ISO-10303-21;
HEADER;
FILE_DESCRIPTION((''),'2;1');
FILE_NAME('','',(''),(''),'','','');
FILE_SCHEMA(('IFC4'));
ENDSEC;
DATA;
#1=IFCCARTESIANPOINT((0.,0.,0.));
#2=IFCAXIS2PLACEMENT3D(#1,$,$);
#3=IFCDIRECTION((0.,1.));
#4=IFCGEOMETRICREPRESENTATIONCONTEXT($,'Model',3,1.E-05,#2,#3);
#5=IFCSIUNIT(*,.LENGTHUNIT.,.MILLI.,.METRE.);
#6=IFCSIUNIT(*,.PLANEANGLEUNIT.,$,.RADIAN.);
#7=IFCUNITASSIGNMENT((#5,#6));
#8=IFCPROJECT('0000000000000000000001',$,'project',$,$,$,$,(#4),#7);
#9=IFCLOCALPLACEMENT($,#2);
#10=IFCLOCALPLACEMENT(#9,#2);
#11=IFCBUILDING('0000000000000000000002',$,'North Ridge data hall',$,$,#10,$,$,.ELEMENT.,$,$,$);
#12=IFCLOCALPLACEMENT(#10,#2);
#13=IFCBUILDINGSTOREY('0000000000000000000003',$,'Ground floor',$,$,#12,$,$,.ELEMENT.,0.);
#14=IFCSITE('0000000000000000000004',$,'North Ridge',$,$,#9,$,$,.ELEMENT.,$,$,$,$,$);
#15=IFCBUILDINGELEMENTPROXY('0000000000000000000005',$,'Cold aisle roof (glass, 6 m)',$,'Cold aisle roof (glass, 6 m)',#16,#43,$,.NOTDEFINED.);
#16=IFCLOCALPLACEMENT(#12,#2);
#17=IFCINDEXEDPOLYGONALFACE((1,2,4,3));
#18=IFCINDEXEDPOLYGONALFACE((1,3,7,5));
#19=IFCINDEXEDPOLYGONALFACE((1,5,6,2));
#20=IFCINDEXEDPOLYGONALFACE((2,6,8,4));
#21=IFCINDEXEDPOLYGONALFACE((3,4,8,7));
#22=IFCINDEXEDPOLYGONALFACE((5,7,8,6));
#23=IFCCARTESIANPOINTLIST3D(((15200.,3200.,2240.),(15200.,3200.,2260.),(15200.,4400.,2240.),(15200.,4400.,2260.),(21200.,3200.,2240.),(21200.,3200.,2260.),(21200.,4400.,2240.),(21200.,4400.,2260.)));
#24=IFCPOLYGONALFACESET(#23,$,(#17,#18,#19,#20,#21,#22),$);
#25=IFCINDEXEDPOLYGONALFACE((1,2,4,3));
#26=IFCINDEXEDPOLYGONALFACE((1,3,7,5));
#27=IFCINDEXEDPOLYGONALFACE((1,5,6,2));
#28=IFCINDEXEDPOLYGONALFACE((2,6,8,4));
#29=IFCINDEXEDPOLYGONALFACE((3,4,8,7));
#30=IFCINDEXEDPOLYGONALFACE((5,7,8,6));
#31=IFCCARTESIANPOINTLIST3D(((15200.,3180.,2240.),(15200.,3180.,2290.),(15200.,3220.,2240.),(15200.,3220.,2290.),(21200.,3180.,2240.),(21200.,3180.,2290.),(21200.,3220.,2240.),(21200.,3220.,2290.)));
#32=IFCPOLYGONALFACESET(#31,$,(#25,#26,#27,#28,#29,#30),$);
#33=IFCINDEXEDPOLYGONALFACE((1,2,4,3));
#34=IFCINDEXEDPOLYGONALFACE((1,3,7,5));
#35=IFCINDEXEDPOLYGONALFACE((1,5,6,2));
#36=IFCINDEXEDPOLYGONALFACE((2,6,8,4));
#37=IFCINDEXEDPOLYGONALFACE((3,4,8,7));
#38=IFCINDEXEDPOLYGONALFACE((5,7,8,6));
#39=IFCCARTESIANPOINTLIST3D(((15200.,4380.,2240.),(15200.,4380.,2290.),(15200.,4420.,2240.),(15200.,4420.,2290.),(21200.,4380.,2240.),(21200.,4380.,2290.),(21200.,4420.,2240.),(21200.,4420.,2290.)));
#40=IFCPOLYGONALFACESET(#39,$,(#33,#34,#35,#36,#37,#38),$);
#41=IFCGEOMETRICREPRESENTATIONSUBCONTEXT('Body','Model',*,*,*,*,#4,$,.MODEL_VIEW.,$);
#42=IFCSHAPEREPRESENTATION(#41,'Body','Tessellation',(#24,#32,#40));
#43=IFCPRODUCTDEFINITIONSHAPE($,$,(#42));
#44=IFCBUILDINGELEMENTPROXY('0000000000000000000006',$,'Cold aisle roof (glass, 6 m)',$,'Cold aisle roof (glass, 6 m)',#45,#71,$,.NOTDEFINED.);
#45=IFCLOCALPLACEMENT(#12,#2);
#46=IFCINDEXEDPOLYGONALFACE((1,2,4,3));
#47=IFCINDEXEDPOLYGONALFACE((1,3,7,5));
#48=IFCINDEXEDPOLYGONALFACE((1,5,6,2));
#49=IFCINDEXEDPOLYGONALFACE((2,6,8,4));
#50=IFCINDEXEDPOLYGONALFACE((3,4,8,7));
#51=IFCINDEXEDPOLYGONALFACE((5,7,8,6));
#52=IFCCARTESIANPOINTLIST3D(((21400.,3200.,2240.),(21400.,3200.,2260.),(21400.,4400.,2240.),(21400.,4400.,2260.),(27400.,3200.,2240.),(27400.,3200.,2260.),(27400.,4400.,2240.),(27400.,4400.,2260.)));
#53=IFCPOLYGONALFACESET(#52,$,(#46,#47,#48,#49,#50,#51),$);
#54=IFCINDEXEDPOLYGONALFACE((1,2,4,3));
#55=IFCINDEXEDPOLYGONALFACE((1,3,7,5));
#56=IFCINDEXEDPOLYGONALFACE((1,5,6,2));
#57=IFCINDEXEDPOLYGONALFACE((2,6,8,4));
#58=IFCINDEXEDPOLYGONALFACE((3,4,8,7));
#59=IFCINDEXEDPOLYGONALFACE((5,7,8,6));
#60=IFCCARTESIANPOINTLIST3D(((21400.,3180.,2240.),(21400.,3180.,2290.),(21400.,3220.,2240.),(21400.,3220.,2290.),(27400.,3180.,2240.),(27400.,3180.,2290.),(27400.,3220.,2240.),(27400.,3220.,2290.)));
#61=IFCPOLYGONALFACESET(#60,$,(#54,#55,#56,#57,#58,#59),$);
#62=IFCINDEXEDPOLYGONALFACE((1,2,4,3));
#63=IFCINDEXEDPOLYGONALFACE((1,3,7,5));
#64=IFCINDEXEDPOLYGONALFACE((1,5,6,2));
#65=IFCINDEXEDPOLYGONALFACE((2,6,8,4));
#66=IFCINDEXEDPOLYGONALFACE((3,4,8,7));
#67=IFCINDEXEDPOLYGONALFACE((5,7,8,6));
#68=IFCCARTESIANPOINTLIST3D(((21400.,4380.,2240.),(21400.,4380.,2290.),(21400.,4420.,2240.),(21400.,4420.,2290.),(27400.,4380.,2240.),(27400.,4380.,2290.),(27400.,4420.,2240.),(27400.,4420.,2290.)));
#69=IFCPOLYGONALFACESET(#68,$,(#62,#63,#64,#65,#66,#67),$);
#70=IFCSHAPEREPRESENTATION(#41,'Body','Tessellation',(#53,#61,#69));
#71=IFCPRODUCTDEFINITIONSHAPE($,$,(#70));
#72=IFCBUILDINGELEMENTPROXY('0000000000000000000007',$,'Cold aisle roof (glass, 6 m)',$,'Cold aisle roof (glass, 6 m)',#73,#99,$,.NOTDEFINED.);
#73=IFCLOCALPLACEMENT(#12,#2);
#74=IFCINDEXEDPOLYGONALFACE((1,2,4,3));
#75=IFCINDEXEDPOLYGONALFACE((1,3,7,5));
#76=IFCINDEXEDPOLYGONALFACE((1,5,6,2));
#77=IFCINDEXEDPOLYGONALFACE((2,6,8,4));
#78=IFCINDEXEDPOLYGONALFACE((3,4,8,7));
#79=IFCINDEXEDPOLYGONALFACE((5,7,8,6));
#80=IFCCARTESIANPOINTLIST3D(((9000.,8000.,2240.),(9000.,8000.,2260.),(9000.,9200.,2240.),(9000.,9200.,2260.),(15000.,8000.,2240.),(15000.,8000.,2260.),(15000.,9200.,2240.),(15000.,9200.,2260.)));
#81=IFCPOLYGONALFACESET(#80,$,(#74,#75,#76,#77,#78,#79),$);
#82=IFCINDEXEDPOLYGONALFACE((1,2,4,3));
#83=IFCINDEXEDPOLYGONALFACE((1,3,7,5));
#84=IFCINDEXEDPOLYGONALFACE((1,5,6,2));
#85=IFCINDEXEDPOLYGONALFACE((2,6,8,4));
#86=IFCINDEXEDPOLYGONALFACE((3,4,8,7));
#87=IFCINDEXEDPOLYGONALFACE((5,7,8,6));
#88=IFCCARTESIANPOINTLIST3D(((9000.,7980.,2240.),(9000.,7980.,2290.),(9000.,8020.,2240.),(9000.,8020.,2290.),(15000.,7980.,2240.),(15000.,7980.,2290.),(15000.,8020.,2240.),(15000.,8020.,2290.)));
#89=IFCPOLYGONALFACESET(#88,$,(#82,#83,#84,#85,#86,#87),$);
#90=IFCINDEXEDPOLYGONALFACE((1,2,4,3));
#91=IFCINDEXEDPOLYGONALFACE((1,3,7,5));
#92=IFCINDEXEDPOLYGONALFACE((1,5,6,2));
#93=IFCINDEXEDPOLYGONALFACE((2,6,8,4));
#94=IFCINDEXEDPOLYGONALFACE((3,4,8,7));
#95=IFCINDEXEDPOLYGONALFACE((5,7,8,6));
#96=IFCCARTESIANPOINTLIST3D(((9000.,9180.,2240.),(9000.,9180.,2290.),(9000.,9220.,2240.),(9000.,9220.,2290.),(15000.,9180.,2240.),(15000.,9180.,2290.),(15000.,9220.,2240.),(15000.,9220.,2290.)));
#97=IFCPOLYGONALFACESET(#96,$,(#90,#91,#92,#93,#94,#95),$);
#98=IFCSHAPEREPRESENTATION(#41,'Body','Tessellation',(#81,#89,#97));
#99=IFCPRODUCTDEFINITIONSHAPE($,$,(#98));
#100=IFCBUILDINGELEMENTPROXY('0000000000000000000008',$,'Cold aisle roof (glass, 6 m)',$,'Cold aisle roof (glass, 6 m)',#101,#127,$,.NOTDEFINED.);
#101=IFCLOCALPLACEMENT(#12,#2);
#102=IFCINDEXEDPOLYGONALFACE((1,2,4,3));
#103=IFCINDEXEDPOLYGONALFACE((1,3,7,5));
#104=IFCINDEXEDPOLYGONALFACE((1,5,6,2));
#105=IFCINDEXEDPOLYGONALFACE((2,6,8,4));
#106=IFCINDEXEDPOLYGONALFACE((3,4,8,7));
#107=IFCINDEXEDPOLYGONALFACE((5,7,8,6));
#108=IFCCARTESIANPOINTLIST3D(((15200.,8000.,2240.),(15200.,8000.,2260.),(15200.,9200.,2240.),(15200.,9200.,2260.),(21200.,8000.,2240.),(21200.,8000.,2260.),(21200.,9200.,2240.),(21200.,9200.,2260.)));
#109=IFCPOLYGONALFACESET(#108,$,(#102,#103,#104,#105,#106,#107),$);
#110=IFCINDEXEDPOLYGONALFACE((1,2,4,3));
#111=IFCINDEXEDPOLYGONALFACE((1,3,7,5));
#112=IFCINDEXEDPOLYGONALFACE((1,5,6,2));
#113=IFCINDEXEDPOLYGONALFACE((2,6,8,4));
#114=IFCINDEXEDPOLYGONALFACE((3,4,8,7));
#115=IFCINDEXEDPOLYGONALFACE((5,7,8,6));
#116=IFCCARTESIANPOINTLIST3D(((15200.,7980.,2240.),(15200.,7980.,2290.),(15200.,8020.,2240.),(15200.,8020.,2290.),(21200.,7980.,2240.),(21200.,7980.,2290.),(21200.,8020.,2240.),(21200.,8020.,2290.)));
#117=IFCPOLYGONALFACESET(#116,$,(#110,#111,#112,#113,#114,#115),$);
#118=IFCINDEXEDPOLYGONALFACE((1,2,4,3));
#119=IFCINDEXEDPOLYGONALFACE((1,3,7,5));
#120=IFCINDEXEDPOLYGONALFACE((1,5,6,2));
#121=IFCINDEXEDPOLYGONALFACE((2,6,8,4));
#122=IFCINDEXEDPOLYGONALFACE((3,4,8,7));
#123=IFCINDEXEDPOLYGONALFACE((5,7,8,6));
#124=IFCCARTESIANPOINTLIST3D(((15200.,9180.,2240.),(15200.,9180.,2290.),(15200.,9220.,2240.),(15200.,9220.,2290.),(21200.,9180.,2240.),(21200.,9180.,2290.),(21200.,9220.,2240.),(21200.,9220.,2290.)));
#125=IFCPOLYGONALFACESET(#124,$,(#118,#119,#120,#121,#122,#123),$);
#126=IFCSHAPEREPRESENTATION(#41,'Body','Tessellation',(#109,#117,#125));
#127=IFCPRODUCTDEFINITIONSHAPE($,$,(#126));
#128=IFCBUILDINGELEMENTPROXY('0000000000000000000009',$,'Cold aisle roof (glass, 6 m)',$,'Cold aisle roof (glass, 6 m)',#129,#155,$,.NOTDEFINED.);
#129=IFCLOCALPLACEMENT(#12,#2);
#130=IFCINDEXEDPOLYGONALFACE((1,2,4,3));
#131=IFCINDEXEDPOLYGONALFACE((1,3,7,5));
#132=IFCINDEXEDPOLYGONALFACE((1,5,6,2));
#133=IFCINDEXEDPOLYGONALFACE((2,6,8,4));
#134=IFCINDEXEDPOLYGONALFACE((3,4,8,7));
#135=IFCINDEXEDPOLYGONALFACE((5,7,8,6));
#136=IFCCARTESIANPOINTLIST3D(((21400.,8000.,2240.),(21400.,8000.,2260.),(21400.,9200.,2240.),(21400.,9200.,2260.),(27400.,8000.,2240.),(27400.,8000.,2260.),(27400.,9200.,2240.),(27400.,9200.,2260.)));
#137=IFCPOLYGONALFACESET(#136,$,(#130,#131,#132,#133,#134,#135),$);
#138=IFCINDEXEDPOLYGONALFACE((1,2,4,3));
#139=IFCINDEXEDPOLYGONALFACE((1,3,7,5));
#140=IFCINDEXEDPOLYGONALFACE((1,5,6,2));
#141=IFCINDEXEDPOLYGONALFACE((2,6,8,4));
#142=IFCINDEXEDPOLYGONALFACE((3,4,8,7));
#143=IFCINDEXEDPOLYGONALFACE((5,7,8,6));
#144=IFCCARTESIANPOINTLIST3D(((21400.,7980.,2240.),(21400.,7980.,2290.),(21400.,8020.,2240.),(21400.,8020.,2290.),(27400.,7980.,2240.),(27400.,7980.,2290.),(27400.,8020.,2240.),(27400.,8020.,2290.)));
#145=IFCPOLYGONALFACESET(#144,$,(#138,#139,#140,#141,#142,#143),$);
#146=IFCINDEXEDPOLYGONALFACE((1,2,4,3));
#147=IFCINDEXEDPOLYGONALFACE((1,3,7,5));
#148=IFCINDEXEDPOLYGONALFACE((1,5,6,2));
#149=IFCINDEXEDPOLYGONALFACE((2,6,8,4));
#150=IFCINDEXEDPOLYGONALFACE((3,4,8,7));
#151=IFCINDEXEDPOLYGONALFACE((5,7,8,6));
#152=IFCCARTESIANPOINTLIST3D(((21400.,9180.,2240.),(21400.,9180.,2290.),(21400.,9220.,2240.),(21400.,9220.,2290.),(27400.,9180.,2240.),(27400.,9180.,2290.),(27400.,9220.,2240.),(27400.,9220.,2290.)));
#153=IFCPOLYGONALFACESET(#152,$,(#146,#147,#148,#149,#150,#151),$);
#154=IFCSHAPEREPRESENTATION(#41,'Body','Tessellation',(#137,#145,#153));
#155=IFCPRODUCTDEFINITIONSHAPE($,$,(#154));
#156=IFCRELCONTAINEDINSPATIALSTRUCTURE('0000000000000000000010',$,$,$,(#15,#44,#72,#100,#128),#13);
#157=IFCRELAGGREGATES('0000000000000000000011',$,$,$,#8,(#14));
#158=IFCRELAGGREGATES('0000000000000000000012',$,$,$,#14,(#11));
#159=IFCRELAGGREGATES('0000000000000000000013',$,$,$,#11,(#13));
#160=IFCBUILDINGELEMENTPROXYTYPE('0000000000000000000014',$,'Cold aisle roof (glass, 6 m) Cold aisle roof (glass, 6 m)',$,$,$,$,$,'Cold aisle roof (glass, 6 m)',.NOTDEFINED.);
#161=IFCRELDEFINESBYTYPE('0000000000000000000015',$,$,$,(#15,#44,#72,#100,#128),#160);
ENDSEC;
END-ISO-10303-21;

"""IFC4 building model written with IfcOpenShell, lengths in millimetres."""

from ifc_helpers import new_model, si_unit, direction, frame, origin, place, context, subcontext, project, spatial, polyline, outline, extrude, source, transform, mapped, type_object, type_shapes, element, save


model = new_model("IFC4")

# Units and contexts
model_context = context("Model", 3, precision=1e-05, world=origin(), true_north=direction((0.0, 1.0)))
body_context = subcontext(model_context, "Body", "Model", "MODEL_VIEW")
ifc_project = project(units=[si_unit("LENGTHUNIT", "METRE", prefix="MILLI"), si_unit("PLANEANGLEUNIT", "RADIAN")], contexts=[model_context])

# Site, building, storey
site_placement = place(None, origin())
site = spatial("IfcSite", under=ifc_project, at=site_placement, Name="North Ridge", CompositionType="ELEMENT")
building_placement = place(site_placement, origin())
building = spatial("IfcBuilding", under=site, at=building_placement, Name="North Ridge data hall", CompositionType="ELEMENT")
storey_placement = place(building_placement, origin())
storey = spatial("IfcBuildingStorey", under=building, at=storey_placement, Name="Ground floor", CompositionType="ELEMENT", Elevation=0.0)

# Building element proxies
building_element_proxy_type_1 = type_object("IfcBuildingElementProxyType", Name="Cold aisle roof (glass, 6 m) Cold aisle roof (glass, 6 m)", ElementType="Cold aisle roof (glass, 6 m)", PredefinedType="NOTDEFINED")
shared_shape_1 = source(origin(), body_context, "Body", "SweptSolid", [
    extrude(outline(polyline([(0.0, 0.0), (6000.0, 0.0), (6000.0, 1200.0), (0.0, 1200.0), (0.0, 0.0)])), frame((0.0, 0.0, 2240.0)), (0.0, 0.0, 1.0), 20.0),
    extrude(outline(polyline([(0.0, -20.0), (6000.0, -20.0), (6000.0, 20.0), (0.0, 20.0), (0.0, -20.0)])), frame((0.0, 0.0, 2240.0)), (0.0, 0.0, 1.0), 50.0),
    extrude(outline(polyline([(0.0, 1180.0), (6000.0, 1180.0), (6000.0, 1220.0), (0.0, 1220.0), (0.0, 1180.0)])), frame((0.0, 0.0, 2240.0)), (0.0, 0.0, 1.0), 50.0),
])
type_shapes(building_element_proxy_type_1, [shared_shape_1])
for number, where, z_axis, x_axis, name in (
    (1, (15200.0, 3200.0, 0.0), (0.0, 0.0, 1.0), (1.0, 0.0, 0.0), "Cold aisle roof (glass, 6 m)"),
    (2, (21400.0, 3200.0, 0.0), (0.0, 0.0, 1.0), (1.0, 0.0, 0.0), "Cold aisle roof (glass, 6 m)"),
    (3, (9000.0, 8000.0, 0.0), (0.0, 0.0, 1.0), (1.0, 0.0, 0.0), "Cold aisle roof (glass, 6 m)"),
    (4, (15200.0, 8000.0, 0.0), (0.0, 0.0, 1.0), (1.0, 0.0, 0.0), "Cold aisle roof (glass, 6 m)"),
    (5, (21400.0, 8000.0, 0.0), (0.0, 0.0, 1.0), (1.0, 0.0, 0.0), "Cold aisle roof (glass, 6 m)"),
):
    element("IfcBuildingElementProxy", number, at=place(storey_placement, frame(where, z_axis=z_axis, x_axis=x_axis)), inside=storey, type_object=building_element_proxy_type_1, Name=name, ObjectType="Cold aisle roof (glass, 6 m)", PredefinedType="NOTDEFINED", context=body_context, shape_type="MappedRepresentation", body=[
        mapped(shared_shape_1, transform((0.0, 0.0, 0.0))),
    ])

save(model, "model.ifc")
